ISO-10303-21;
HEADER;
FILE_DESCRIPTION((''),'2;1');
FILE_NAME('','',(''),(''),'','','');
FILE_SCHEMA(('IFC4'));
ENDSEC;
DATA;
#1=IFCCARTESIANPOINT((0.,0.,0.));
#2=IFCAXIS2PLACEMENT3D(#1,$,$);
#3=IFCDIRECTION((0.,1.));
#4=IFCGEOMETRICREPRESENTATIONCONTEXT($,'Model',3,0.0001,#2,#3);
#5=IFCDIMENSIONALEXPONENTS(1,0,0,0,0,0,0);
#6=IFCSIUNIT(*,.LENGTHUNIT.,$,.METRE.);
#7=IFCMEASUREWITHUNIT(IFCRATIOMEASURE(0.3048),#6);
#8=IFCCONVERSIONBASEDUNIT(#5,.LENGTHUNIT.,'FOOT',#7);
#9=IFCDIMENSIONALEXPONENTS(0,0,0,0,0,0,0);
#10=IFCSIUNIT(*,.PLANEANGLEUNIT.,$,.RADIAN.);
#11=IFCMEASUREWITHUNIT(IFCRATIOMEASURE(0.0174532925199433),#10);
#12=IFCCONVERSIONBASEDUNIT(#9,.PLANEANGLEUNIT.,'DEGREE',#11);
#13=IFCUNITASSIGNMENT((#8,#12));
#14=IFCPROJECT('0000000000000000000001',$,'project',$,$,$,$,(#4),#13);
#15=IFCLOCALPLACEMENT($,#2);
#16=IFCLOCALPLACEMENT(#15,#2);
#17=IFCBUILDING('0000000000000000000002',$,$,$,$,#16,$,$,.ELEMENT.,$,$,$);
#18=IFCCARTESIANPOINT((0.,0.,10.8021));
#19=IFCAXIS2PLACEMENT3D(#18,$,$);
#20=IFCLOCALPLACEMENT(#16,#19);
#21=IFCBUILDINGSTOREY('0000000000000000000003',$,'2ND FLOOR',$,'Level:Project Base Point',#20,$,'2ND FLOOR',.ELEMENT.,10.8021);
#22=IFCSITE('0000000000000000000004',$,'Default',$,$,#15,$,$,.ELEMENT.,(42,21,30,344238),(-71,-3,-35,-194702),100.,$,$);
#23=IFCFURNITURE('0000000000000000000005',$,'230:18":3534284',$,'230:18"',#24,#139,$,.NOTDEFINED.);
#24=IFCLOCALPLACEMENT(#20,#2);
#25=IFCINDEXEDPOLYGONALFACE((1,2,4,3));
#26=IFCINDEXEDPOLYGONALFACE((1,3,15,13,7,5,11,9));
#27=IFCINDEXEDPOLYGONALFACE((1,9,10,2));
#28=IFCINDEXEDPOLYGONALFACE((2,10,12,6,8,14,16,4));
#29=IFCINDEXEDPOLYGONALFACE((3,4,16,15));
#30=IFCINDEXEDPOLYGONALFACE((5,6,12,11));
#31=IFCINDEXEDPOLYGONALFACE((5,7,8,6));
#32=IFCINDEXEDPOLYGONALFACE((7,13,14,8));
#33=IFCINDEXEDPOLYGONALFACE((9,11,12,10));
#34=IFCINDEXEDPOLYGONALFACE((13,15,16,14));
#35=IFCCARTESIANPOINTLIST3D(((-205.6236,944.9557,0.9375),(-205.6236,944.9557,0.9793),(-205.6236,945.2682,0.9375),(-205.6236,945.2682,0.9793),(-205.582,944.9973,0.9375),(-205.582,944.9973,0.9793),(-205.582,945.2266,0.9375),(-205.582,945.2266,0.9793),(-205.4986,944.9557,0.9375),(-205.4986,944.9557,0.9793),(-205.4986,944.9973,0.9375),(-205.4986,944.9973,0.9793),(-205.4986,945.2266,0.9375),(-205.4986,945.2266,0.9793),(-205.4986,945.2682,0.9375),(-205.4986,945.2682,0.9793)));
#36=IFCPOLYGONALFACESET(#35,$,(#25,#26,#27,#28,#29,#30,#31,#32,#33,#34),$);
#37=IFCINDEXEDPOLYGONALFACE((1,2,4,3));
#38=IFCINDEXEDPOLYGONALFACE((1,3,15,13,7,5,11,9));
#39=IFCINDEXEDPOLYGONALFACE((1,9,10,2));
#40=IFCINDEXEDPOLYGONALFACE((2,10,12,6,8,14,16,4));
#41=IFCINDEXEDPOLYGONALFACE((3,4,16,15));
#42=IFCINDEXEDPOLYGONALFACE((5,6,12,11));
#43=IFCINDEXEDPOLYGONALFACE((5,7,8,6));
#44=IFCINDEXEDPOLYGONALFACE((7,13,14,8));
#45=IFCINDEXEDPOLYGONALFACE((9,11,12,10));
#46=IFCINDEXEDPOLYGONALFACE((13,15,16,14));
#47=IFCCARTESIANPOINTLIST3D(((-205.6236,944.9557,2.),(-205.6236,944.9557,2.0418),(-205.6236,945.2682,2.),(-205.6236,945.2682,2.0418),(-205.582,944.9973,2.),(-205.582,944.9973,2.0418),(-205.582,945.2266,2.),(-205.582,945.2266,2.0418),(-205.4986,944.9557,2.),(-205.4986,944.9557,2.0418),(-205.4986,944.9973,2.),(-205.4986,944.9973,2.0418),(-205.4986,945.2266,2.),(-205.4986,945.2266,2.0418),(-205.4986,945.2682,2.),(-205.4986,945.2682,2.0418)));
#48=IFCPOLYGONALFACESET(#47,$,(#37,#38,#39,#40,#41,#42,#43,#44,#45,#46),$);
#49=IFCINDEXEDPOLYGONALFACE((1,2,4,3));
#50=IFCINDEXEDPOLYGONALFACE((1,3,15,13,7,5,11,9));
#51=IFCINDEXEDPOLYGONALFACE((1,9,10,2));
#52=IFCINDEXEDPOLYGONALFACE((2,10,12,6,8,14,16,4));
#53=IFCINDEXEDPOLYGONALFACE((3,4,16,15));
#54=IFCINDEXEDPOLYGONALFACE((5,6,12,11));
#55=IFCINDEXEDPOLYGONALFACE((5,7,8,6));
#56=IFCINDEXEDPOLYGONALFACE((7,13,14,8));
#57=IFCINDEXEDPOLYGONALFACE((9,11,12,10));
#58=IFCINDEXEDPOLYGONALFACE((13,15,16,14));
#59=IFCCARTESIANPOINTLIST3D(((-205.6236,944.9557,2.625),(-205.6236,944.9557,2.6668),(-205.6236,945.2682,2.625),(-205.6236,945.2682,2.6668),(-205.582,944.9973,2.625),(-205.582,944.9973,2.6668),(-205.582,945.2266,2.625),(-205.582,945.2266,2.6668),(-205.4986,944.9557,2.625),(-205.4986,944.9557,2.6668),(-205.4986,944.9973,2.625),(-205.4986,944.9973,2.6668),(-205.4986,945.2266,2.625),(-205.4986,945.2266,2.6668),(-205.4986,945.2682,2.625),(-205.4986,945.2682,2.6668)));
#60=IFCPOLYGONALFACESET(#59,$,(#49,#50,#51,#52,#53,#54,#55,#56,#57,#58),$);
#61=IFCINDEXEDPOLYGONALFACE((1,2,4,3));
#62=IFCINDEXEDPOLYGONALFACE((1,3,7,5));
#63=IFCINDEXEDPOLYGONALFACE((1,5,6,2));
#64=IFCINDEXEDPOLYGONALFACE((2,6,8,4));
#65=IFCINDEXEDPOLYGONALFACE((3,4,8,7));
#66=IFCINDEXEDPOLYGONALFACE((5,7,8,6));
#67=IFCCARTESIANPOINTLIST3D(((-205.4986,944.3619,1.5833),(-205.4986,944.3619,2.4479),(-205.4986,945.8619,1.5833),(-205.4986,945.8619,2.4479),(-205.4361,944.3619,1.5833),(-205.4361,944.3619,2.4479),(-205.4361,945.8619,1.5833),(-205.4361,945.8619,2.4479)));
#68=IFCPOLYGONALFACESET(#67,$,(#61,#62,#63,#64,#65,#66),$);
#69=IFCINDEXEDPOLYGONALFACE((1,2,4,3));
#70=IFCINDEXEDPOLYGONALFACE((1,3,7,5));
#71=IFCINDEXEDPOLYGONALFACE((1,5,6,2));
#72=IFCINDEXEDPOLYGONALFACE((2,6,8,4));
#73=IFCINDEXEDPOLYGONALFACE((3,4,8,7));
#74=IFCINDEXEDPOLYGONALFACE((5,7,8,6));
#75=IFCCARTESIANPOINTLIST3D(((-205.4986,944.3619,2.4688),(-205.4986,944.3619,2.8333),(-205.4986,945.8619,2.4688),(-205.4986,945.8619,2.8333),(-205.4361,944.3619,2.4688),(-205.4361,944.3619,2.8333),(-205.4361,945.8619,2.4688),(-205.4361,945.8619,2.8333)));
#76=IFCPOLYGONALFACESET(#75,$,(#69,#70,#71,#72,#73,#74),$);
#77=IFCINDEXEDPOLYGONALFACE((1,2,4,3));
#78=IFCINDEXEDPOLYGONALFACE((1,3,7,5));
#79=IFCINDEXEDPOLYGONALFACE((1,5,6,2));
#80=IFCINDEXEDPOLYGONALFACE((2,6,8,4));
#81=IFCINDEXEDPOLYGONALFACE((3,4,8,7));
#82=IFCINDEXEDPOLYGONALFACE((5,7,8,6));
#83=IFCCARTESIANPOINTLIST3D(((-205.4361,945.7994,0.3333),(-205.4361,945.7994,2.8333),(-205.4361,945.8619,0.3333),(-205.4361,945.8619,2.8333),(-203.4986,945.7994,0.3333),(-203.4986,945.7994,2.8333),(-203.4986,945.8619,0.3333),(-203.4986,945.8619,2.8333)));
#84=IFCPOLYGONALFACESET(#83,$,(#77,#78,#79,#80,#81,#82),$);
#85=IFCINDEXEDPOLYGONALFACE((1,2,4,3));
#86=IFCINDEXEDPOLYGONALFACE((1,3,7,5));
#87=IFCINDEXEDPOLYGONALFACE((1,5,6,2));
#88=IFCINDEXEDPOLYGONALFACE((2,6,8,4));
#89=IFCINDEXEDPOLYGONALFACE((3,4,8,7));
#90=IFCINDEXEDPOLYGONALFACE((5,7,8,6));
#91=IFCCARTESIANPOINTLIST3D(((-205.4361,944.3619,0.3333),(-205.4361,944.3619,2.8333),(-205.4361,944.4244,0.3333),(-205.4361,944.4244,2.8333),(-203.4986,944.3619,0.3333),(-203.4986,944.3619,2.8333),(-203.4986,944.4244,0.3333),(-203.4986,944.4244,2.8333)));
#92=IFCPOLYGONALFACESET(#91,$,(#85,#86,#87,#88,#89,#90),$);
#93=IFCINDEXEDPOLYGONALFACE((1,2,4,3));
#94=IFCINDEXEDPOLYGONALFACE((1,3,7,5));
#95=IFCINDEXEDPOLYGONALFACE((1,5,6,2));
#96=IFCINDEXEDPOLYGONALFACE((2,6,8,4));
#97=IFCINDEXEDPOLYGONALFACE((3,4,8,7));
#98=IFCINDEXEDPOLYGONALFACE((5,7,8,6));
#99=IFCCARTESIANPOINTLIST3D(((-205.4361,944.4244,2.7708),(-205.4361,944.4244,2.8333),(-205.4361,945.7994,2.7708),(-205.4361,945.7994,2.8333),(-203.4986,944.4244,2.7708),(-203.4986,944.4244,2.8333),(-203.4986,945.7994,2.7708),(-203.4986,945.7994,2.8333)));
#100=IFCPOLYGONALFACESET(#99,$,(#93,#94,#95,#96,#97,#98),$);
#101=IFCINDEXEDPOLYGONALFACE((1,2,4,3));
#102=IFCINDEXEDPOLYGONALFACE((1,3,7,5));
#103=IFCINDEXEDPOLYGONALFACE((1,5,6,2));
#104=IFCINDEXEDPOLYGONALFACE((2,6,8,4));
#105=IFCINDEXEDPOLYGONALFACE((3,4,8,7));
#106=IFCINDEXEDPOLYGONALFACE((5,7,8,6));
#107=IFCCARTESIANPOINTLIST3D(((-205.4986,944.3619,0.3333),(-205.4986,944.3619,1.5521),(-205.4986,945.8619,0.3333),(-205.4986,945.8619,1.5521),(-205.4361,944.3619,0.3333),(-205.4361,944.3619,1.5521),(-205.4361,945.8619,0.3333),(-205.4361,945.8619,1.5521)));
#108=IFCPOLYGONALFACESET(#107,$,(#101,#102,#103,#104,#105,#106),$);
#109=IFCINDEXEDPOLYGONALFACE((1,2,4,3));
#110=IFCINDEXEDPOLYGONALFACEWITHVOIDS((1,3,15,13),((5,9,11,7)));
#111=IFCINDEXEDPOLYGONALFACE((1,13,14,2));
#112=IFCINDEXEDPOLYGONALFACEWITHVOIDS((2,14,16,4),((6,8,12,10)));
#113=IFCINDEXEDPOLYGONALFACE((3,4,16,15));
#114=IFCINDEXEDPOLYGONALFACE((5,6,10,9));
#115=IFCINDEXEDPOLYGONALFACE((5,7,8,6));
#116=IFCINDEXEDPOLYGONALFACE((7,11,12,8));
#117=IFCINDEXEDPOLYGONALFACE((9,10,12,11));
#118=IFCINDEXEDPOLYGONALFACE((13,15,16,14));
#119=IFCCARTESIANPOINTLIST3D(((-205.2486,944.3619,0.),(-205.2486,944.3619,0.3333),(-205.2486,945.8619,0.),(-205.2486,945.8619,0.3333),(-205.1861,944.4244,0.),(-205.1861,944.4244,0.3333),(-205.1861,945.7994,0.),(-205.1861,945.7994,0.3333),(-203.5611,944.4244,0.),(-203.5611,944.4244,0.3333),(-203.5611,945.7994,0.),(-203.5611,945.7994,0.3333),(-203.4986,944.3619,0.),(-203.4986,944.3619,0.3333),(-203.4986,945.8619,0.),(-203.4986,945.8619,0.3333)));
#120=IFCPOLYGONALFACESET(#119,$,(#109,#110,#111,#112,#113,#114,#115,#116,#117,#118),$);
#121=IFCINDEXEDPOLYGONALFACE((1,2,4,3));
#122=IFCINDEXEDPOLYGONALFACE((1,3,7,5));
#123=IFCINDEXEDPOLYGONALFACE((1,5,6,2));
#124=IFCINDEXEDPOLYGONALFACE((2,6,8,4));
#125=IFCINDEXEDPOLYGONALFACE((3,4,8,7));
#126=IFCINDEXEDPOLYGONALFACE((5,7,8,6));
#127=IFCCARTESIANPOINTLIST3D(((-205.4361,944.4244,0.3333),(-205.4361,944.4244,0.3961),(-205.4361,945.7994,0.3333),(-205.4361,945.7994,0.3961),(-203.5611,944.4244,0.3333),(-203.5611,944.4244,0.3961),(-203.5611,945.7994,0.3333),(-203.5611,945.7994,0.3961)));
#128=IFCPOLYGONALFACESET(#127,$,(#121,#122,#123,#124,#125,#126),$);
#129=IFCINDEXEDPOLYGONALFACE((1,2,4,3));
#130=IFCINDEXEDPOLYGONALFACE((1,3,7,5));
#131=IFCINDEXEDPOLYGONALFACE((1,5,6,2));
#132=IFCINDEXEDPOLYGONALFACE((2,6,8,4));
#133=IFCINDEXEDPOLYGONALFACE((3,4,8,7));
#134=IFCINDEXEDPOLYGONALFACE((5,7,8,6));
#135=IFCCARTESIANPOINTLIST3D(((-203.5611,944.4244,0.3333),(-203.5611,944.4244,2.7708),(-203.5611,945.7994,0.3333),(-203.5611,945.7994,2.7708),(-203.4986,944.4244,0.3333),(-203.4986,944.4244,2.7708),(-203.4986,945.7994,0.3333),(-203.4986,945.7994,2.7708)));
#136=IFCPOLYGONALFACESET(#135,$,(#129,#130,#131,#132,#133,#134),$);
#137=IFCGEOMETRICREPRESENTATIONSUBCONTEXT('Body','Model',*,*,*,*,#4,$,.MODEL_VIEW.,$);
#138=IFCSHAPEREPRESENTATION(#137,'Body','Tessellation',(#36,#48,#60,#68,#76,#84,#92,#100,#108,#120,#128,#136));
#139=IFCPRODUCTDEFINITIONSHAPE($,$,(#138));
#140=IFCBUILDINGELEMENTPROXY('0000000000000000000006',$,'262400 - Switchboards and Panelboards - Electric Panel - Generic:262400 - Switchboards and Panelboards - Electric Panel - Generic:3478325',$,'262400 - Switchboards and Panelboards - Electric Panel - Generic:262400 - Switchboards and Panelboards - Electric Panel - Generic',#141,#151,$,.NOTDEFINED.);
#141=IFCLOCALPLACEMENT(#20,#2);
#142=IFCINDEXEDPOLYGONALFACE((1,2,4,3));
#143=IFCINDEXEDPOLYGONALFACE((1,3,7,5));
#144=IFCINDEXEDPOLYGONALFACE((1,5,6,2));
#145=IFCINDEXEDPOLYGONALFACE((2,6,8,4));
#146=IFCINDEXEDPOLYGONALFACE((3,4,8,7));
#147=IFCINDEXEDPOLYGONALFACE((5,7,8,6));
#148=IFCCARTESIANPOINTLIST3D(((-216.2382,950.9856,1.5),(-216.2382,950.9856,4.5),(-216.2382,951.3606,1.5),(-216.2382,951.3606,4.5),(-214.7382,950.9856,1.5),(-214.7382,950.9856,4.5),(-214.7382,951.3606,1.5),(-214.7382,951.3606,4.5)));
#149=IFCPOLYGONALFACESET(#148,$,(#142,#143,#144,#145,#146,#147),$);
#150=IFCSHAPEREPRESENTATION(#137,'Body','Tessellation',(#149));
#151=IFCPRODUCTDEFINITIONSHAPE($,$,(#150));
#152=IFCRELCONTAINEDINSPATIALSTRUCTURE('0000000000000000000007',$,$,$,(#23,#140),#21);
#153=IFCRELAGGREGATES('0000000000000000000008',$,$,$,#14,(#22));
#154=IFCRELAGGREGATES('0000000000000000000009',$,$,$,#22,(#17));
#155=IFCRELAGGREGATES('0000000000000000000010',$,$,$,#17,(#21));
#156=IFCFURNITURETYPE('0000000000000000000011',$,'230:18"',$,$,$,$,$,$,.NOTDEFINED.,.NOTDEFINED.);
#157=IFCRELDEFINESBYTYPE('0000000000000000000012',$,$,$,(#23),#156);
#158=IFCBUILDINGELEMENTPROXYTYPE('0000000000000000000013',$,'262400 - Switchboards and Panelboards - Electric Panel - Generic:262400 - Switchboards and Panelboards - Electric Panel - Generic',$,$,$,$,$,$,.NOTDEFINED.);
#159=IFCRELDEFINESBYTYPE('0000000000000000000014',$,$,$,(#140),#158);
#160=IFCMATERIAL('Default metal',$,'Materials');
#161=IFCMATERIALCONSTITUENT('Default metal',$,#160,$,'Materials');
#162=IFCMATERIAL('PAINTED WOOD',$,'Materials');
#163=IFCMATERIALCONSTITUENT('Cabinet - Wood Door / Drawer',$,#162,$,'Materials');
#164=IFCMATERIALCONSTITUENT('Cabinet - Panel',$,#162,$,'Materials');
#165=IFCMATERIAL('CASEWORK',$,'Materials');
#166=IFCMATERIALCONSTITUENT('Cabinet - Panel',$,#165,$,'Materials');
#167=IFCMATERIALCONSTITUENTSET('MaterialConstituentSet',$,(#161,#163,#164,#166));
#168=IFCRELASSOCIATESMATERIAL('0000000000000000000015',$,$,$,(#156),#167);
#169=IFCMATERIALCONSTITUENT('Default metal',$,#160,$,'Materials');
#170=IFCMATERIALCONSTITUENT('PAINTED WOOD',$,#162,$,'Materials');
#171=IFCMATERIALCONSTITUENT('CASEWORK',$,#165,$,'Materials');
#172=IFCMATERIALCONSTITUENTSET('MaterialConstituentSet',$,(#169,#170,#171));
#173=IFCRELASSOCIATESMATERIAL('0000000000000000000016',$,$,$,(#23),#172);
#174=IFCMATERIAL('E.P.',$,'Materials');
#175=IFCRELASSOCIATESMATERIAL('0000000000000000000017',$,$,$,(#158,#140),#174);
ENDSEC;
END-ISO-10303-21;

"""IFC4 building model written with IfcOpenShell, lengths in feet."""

from ifc_helpers import new_model, entity, si_unit, converted_unit, direction, frame, frame_2d, origin, origin_2d_with_axis, place, context, subcontext, project, spatial, polyline, rectangle, outline, extrude, source, transform, mapped, material, constituent, constituent_set, type_object, type_shapes, element, save


model = new_model("IFC4")

# Units and contexts
model_context = context("Model", 3, precision=0.0001, world=origin(), true_north=direction((0.0, 1.0)))
body_context = subcontext(model_context, "Body", "Model", "MODEL_VIEW")
ifc_project = project(units=[converted_unit("LENGTHUNIT", "FOOT", entity("IfcRatioMeasure", 0.3048), si_unit("LENGTHUNIT", "METRE"), dimensions=[1, 0, 0, 0, 0, 0, 0]), converted_unit("PLANEANGLEUNIT", "DEGREE", entity("IfcRatioMeasure", 0.0174532925199433), si_unit("PLANEANGLEUNIT", "RADIAN"), dimensions=[0, 0, 0, 0, 0, 0, 0])], contexts=[model_context])

# Site, building, storey
site_placement = place(None, origin())
site = spatial("IfcSite", under=ifc_project, at=site_placement, Name="Default", CompositionType="ELEMENT", RefLatitude=(42, 21, 30, 344238), RefLongitude=(-71, -3, -35, -194702), RefElevation=100.0)
building_placement = place(site_placement, origin())
building = spatial("IfcBuilding", under=site, at=building_placement, CompositionType="ELEMENT")
storey_placement = place(building_placement, frame((0.0, 0.0, 10.8021)))
storey = spatial("IfcBuildingStorey", under=building, at=storey_placement, Name="2ND FLOOR", ObjectType="Level:Project Base Point", LongName="2ND FLOOR", CompositionType="ELEMENT", Elevation=10.8021)

# Furniture
ifc_material_1 = material(Name="CASEWORK", Category="Materials")
ifc_material_2 = material(Name="PAINTED WOOD", Category="Materials")
ifc_material_3 = material(Name="Default metal", Category="Materials")
ifc_constituent_1 = constituent(ifc_material_3, Name="Default metal", Category="Materials")
ifc_constituent_2 = constituent(ifc_material_2, Name="PAINTED WOOD", Category="Materials")
ifc_constituent_3 = constituent(ifc_material_1, Name="CASEWORK", Category="Materials")
ifc_constituent_set_1 = constituent_set(constituents=[ifc_constituent_1, ifc_constituent_2, ifc_constituent_3], Name="MaterialConstituentSet")
ifc_constituent_4 = constituent(ifc_material_3, Name="Default metal", Category="Materials")
ifc_constituent_5 = constituent(ifc_material_2, Name="Cabinet - Wood Door / Drawer", Category="Materials")
ifc_constituent_6 = constituent(ifc_material_2, Name="Cabinet - Panel", Category="Materials")
ifc_constituent_7 = constituent(ifc_material_1, Name="Cabinet - Panel", Category="Materials")
ifc_constituent_set_2 = constituent_set(constituents=[ifc_constituent_4, ifc_constituent_5, ifc_constituent_6, ifc_constituent_7], Name="MaterialConstituentSet")
furniture_type_1 = type_object("IfcFurnitureType", Name="230:18\"", AssemblyPlace="NOTDEFINED", PredefinedType="NOTDEFINED", material=ifc_constituent_set_2)
shared_shape_1 = source(origin(), body_context, "Body", "SweptSolid", [
    extrude(outline(polyline([(-0.0521, -0.1562), (0.0729, -0.1562), (0.0729, 0.1562), (-0.0521, 0.1562), (-0.0521, 0.1146), (0.0313, 0.1146), (0.0313, -0.1146), (-0.0521, -0.1146), (-0.0521, -0.1562)])), frame((0.0615, -2.0521, 0.9375), z_axis=(0.0, 0.0, 1.0), x_axis=(0.0, -1.0, 0.0)), (0.0, 0.0, 1.0), 0.0418),
    extrude(outline(polyline([(-0.0521, -0.1562), (0.0729, -0.1562), (0.0729, 0.1562), (-0.0521, 0.1562), (-0.0521, 0.1146), (0.0313, 0.1146), (0.0313, -0.1146), (-0.0521, -0.1146), (-0.0521, -0.1562)])), frame((0.0615, -2.0521, 2.0), z_axis=(0.0, 0.0, 1.0), x_axis=(0.0, -1.0, 0.0)), (0.0, 0.0, 1.0), 0.0418),
    extrude(outline(polyline([(-0.0521, -0.1562), (0.0729, -0.1562), (0.0729, 0.1562), (-0.0521, 0.1562), (-0.0521, 0.1146), (0.0313, 0.1146), (0.0313, -0.1146), (-0.0521, -0.1146), (-0.0521, -0.1562)])), frame((0.0615, -2.0521, 2.625), z_axis=(0.0, 0.0, 1.0), x_axis=(0.0, -1.0, 0.0)), (0.0, 0.0, 1.0), 0.0418),
    extrude(rectangle(XDim=0.0625, YDim=1.5, at=frame_2d((0.0, 0.0), x_axis=(1.0, 0.0))), frame((0.0615, -1.9688, 1.5833), z_axis=(0.0, 0.0, 1.0), x_axis=(0.0, 1.0, 0.0)), (0.0, 0.0, 1.0), 0.8646),
    extrude(rectangle(XDim=0.0625, YDim=1.5, at=frame_2d((0.0, 0.0), x_axis=(1.0, 0.0))), frame((0.0615, -1.9688, 2.4688), z_axis=(0.0, 0.0, 1.0), x_axis=(0.0, 1.0, 0.0)), (0.0, 0.0, 1.0), 0.3646),
    extrude(rectangle(XDim=0.0625, YDim=1.9375, at=frame_2d((0.0, 0.0), x_axis=(1.0, 0.0))), frame((-0.6573, -0.9687, 0.3333)), (0.0, 0.0, 1.0), 2.5),
    extrude(rectangle(XDim=0.0625, YDim=1.9375, at=frame_2d((0.0, 0.0), x_axis=(1.0, 0.0))), frame((0.7802, -0.9687, 0.3333)), (0.0, 0.0, 1.0), 2.5),
    extrude(rectangle(XDim=1.375, YDim=1.9375, at=origin_2d_with_axis()), frame((0.0615, -0.9687, 2.7708), z_axis=(0.0, 0.0, 1.0), x_axis=(-1.0, 0.0, 0.0)), (0.0, 0.0, 1.0), 0.0625),
    extrude(rectangle(XDim=0.0625, YDim=1.5, at=frame_2d((0.0, 0.0), x_axis=(1.0, 0.0))), frame((0.0615, -1.9688, 0.3333), z_axis=(0.0, 0.0, 1.0), x_axis=(0.0, 1.0, 0.0)), (0.0, 0.0, 1.0), 1.2187),
    extrude(outline(polyline([(-0.75, -0.875), (0.75, -0.875), (0.75, 0.875), (-0.75, 0.875), (-0.75, -0.875)]), holes=[polyline([(-0.6875, -0.8125), (-0.6875, 0.8125), (0.6875, 0.8125), (0.6875, -0.8125), (-0.6875, -0.8125)])]), frame((0.0615, -0.875, 0.0)), (0.0, 0.0, 1.0), 0.3333),
    extrude(rectangle(XDim=1.375, YDim=1.875, at=frame_2d((0.0, 0.0), x_axis=(1.0, 0.0))), frame((0.0615, -1.0, 0.3333), z_axis=(0.0, 0.0, 1.0), x_axis=(-1.0, 0.0, 0.0)), (0.0, 0.0, 1.0), 0.0627),
    extrude(rectangle(XDim=0.0625, YDim=1.375, at=origin_2d_with_axis()), frame((0.0615, -0.0312, 0.3333), z_axis=(0.0, 0.0, 1.0), x_axis=(0.0, 1.0, 0.0)), (0.0, 0.0, 1.0), 2.4375),
])
type_shapes(furniture_type_1, [shared_shape_1])
furniture_1_placement = place(storey_placement, frame((-203.4986, 945.1734, 0.0), z_axis=(0.0, 0.0, 1.0), x_axis=(0.0, -1.0, 0.0)))
element("IfcFurniture", 1, at=furniture_1_placement, inside=storey, type_object=furniture_type_1, material=ifc_constituent_set_1, Name="230:18\":3534284", ObjectType="230:18\"", PredefinedType="NOTDEFINED", context=body_context, shape_type="MappedRepresentation", body=[
    mapped(shared_shape_1, transform((0.0, 0.0, 0.0), scale=1.0)),
])

# Building element proxy
ifc_material_4 = material(Name="E.P.", Category="Materials")
building_element_proxy_type_1 = type_object("IfcBuildingElementProxyType", Name="262400 - Switchboards and Panelboards - Electric Panel - Generic:262400 - Switchboards and Panelboards - Electric Panel - Generic", PredefinedType="NOTDEFINED", material=ifc_material_4)
shared_shape_2 = source(origin(), body_context, "Body", "SweptSolid", [
    extrude(rectangle(XDim=1.5, YDim=0.375, at=origin_2d_with_axis()), frame((0.75, 0.1875, 0.0), z_axis=(0.0, 0.0, 1.0), x_axis=(-1.0, 0.0, 0.0)), (0.0, 0.0, 1.0), 3.0),
])
type_shapes(building_element_proxy_type_1, [shared_shape_2])
proxy_1_placement = place(storey_placement, frame((-214.7382, 951.3606, 1.5), z_axis=(0.0, 0.0, 1.0), x_axis=(-1.0, 0.0, 0.0)))
element("IfcBuildingElementProxy", 2, at=proxy_1_placement, inside=storey, type_object=building_element_proxy_type_1, material=ifc_material_4, Name="262400 - Switchboards and Panelboards - Electric Panel - Generic:262400 - Switchboards and Panelboards - Electric Panel - Generic:3478325", ObjectType="262400 - Switchboards and Panelboards - Electric Panel - Generic:262400 - Switchboards and Panelboards - Electric Panel - Generic", PredefinedType="NOTDEFINED", context=body_context, shape_type="MappedRepresentation", body=[
    mapped(shared_shape_2, transform((0.0, 0.0, 0.0), scale=1.0)),
])

save(model, "model.ifc")
